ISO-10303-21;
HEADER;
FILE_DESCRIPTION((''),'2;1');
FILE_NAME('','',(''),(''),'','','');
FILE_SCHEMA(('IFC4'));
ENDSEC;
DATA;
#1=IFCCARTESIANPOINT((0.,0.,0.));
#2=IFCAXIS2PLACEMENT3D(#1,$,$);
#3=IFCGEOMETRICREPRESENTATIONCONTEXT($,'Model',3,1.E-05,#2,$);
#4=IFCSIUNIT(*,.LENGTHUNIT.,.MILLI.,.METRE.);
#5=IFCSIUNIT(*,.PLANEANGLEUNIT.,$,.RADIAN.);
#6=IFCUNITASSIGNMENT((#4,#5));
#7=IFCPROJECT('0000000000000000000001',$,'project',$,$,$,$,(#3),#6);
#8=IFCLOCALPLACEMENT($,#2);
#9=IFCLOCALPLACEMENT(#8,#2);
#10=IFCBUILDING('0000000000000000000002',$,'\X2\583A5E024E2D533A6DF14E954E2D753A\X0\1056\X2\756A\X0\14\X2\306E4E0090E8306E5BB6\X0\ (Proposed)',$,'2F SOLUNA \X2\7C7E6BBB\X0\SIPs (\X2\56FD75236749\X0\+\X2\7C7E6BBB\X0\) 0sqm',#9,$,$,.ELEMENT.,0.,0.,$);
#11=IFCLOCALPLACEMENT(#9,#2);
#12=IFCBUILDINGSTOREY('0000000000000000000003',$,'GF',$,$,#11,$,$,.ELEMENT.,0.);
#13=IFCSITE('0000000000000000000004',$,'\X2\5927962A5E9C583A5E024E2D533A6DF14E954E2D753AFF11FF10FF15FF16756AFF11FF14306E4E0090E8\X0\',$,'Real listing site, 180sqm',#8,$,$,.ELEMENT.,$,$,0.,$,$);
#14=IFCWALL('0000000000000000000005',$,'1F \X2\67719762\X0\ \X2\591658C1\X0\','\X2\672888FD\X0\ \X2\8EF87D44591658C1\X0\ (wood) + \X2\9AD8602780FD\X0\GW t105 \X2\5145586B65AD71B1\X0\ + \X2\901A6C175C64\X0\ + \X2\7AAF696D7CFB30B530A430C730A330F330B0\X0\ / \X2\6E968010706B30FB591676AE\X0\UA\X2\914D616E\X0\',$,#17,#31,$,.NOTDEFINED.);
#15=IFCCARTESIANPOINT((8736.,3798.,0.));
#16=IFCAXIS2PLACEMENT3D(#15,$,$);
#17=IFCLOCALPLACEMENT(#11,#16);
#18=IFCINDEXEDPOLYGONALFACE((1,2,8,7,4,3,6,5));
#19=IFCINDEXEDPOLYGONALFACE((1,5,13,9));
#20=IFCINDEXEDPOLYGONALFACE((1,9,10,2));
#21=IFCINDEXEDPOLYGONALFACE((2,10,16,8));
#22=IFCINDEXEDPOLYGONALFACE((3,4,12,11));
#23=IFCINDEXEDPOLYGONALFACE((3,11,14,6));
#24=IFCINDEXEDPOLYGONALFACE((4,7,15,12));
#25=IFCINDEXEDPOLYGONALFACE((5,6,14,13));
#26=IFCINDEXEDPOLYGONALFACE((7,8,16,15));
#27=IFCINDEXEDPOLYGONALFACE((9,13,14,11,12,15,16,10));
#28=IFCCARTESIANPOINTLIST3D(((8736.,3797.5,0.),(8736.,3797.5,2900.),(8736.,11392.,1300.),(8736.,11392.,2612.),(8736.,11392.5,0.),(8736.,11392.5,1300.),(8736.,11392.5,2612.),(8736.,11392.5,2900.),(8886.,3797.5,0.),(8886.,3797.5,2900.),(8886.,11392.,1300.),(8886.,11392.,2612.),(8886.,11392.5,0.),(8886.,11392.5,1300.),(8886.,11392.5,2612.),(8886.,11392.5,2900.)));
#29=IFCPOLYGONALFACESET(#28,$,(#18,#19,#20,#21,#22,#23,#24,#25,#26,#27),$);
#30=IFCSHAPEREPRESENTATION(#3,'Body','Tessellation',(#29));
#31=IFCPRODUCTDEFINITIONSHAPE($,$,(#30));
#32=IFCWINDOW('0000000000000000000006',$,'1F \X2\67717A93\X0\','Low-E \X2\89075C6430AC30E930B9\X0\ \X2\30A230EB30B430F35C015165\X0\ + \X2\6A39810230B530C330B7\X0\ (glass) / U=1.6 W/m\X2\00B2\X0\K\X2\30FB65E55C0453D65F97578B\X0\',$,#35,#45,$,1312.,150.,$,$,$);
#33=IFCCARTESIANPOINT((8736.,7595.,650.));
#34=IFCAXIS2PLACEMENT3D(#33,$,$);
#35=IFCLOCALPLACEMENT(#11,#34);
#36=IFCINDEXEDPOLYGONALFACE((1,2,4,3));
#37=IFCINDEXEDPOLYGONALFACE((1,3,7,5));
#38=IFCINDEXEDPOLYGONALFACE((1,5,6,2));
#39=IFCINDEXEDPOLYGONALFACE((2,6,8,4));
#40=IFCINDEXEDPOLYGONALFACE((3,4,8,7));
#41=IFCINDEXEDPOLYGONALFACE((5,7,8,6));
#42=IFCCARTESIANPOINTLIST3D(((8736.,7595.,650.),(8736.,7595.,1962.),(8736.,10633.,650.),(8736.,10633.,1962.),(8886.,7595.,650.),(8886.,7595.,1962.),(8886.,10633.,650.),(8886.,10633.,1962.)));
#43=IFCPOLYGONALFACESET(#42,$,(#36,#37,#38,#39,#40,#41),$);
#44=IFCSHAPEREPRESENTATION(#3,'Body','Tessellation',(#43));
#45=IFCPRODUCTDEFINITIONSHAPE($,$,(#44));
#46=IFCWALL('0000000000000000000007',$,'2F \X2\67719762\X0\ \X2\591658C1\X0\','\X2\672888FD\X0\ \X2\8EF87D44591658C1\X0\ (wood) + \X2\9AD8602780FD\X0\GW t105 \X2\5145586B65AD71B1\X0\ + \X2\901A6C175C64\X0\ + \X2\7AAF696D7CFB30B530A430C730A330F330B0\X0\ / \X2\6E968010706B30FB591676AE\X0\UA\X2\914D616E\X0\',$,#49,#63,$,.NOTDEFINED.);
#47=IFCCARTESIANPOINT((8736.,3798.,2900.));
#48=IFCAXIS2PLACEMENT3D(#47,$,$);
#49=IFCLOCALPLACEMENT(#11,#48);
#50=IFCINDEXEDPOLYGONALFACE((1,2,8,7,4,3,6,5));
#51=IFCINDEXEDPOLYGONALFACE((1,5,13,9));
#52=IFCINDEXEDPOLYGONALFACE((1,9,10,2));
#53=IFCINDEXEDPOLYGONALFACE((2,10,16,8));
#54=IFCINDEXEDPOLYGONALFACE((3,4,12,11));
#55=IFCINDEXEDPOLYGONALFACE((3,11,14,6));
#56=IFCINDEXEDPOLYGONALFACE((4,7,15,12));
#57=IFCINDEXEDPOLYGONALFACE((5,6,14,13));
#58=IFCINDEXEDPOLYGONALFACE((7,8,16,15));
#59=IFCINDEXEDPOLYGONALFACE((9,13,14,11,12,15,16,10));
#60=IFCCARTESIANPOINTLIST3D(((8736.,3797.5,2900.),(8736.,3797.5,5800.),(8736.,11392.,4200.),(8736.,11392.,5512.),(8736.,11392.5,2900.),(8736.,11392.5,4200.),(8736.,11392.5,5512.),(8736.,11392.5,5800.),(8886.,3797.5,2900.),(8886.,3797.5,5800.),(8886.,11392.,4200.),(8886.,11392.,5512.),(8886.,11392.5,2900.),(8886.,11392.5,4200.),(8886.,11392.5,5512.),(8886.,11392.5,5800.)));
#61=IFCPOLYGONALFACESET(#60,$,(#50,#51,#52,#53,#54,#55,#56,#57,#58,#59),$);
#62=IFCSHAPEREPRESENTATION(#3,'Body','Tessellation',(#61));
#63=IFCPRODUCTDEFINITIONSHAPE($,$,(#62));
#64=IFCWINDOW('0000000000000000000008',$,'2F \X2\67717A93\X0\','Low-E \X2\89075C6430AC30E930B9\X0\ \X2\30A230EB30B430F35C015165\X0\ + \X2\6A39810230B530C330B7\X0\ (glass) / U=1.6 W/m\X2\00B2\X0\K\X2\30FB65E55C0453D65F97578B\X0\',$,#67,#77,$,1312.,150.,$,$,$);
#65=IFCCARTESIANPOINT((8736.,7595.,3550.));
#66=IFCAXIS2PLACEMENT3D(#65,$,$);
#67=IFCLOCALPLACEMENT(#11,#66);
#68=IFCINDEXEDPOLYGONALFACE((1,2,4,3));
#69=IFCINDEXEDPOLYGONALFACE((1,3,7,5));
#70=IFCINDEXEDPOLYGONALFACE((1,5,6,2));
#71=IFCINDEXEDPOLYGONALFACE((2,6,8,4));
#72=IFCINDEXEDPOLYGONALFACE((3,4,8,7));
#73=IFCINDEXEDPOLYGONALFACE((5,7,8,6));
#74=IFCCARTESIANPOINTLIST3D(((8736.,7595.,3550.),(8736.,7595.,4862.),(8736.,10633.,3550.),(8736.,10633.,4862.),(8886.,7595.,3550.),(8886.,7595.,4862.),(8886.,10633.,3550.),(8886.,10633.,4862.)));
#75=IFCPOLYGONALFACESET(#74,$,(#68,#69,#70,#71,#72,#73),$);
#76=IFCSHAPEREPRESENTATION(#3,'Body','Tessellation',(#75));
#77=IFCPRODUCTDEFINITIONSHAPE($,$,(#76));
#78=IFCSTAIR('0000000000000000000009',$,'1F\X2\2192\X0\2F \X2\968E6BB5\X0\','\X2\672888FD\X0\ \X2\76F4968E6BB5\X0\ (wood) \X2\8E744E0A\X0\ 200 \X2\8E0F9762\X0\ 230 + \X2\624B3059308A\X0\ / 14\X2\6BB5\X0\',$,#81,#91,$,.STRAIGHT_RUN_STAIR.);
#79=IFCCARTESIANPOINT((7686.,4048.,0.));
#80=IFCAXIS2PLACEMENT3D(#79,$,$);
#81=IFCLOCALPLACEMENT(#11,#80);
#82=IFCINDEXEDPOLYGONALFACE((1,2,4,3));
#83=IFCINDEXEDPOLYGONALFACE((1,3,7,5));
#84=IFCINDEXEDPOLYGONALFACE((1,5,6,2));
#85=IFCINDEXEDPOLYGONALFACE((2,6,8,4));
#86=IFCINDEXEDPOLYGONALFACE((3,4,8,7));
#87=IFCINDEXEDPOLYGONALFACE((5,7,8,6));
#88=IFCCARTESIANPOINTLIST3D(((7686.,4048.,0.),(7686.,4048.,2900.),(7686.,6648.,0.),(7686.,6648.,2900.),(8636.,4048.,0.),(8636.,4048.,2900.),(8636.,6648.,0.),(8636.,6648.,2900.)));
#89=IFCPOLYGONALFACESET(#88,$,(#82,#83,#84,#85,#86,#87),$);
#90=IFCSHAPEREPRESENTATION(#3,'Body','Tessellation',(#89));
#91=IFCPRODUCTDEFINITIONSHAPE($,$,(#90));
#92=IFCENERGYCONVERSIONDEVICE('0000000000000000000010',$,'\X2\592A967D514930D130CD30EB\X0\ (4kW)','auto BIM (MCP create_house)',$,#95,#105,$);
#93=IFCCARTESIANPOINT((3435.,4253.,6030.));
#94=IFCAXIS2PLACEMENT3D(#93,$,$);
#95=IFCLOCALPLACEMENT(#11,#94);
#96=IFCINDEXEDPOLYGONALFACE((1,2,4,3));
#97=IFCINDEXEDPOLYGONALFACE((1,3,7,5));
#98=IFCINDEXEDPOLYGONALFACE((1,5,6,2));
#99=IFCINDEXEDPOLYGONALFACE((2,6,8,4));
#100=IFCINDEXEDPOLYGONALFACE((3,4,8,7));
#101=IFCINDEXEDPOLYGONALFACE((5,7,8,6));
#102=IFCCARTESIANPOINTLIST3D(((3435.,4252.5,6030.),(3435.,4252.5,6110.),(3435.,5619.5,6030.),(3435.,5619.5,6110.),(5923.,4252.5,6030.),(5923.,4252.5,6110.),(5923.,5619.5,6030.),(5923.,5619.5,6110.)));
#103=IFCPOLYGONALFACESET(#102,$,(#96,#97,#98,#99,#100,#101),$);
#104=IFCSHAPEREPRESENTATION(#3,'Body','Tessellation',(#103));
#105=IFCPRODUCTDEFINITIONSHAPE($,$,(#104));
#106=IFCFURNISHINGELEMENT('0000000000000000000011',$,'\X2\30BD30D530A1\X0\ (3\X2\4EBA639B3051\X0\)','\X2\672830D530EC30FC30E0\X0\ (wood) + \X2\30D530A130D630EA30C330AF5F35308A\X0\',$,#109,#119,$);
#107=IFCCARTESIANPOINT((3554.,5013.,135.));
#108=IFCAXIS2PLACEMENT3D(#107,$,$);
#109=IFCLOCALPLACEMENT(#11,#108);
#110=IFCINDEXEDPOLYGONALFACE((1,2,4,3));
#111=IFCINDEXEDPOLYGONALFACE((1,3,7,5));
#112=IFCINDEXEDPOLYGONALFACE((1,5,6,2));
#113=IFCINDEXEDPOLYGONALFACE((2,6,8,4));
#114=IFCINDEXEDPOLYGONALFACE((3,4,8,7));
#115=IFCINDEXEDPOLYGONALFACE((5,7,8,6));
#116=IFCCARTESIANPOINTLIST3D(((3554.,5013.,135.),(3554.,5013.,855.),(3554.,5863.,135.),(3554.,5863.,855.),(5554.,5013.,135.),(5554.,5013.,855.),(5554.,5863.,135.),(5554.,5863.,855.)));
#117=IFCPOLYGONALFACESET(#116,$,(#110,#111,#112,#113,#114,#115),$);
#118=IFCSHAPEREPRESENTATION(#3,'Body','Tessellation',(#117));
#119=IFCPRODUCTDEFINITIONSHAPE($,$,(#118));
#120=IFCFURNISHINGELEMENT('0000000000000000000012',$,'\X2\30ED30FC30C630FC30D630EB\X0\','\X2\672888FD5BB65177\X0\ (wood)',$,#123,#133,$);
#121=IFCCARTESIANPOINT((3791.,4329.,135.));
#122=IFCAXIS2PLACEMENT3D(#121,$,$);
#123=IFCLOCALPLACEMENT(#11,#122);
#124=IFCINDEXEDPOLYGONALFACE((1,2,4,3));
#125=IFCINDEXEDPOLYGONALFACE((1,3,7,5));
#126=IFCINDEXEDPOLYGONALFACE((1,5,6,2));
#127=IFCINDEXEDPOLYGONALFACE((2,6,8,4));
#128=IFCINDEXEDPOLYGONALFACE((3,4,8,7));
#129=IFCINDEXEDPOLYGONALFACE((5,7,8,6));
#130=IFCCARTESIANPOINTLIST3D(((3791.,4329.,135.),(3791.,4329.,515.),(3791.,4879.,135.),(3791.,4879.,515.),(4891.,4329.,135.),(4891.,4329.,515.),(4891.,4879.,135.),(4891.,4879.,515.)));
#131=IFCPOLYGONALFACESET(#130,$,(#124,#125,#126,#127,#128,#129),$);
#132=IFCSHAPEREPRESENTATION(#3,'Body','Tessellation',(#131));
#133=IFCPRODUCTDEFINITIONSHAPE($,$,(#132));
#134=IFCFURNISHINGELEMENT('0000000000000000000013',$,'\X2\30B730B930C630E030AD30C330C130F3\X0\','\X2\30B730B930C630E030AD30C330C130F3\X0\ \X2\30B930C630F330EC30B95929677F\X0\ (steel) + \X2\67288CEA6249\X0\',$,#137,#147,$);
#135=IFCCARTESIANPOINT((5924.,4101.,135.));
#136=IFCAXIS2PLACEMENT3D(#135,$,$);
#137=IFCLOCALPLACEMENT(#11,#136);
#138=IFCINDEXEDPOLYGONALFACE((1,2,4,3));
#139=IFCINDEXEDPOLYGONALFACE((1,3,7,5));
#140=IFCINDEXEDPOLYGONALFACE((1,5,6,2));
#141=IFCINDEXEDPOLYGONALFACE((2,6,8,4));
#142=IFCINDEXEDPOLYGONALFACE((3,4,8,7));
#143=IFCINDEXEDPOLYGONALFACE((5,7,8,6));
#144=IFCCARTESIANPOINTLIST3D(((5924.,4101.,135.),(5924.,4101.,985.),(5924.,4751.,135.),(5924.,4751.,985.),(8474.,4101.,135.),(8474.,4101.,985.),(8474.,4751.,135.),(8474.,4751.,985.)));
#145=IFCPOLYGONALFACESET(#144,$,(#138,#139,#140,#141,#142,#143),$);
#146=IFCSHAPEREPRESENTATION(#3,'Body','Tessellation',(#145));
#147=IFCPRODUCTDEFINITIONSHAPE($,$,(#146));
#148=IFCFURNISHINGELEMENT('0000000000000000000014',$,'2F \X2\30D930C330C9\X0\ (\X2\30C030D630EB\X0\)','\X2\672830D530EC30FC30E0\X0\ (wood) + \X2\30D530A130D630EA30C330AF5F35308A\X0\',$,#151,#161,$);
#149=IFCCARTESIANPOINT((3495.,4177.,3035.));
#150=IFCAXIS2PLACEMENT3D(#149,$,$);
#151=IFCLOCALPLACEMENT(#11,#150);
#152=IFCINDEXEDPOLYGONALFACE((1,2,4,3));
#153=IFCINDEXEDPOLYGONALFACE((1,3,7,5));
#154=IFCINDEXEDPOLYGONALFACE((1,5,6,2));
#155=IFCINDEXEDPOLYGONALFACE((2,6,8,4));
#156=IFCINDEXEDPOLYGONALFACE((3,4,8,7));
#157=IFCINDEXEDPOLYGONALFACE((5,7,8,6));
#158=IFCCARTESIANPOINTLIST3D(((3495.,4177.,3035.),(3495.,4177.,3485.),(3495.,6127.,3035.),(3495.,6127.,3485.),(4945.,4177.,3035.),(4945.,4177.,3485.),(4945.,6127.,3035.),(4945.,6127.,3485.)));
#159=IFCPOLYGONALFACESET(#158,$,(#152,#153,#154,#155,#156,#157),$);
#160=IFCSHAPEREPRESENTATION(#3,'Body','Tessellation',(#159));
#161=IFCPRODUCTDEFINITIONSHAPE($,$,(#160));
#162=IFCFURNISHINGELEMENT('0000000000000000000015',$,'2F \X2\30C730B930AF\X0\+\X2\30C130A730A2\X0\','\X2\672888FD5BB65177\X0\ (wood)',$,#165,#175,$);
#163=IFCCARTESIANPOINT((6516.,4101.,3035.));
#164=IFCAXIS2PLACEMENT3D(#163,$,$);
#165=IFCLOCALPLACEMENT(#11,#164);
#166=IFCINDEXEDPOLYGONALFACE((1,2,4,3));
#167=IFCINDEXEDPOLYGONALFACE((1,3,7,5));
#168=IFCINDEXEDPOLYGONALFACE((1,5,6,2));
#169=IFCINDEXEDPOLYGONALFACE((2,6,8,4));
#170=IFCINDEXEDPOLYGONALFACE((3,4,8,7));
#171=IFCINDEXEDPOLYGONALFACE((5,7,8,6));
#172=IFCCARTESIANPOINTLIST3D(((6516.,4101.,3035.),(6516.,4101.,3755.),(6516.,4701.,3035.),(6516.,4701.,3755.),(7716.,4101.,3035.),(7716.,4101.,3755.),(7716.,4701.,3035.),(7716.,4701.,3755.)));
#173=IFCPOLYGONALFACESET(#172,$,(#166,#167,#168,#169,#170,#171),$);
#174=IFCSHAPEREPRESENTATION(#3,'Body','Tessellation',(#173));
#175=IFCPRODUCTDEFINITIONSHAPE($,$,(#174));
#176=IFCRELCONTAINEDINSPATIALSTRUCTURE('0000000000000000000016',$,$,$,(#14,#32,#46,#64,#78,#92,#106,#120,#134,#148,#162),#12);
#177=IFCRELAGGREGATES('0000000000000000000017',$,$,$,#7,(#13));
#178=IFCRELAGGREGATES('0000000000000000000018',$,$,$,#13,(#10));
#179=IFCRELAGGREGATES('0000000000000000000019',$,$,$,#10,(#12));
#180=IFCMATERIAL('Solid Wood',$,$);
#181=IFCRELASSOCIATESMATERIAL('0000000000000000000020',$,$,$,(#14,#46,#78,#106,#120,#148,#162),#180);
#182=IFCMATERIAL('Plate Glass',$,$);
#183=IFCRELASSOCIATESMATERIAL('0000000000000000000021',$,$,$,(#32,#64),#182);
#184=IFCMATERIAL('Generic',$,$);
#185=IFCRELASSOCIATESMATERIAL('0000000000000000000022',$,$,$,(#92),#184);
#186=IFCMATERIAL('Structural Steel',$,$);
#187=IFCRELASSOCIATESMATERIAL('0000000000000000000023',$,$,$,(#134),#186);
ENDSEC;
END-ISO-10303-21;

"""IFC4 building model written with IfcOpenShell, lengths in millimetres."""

from ifc_helpers import new_model, si_unit, frame, frame_2d, origin, place, context, project, spatial, rectangle, extrude, material, element, fill, save


model = new_model("IFC4")

# Units and contexts
model_context = context("Model", 3, precision=1e-05, world=origin())
ifc_project = project(units=[si_unit("LENGTHUNIT", "METRE", prefix="MILLI"), si_unit("PLANEANGLEUNIT", "RADIAN")], contexts=[model_context])

# Site, building, storey
site_placement = place(None, origin())
site = spatial("IfcSite", under=ifc_project, at=site_placement, Name="大阪府堺市中区深井中町１０５６番１４の一部", ObjectType="Real listing site, 180sqm", CompositionType="ELEMENT", RefElevation=0.0)
building_placement = place(site_placement, origin())
building = spatial("IfcBuilding", under=site, at=building_placement, Name="堺市中区深井中町1056番14の一部の家 (Proposed)", ObjectType="2F SOLUNA 籾殻SIPs (国産杉+籾殻) 0sqm", CompositionType="ELEMENT", ElevationOfRefHeight=0.0, ElevationOfTerrain=0.0)
storey_placement = place(building_placement, origin())
storey = spatial("IfcBuildingStorey", under=building, at=storey_placement, Name="GF", CompositionType="ELEMENT", Elevation=0.0)

# Wall, opening, window
ifc_material_1 = material(Name="Solid Wood")
wall_1_placement = place(storey_placement, frame((8736.0, 3798.0, 0.0)))
wall_1 = element("IfcWall", 1, at=wall_1_placement, inside=storey, material=ifc_material_1, Name="1F 東面 外壁", Description="木製 軸組外壁 (wood) + 高性能GW t105 充填断熱 + 通気層 + 窯業系サイディング / 準耐火・外皮UA配慮", PredefinedType="NOTDEFINED", context=model_context, shape_type="SweptSolid", body=[
    extrude(rectangle(XDim=150.0, YDim=7595.0, at=frame_2d((75.0, 3797.0))), frame((8736.0, 3798.0, 0.0)), (0.0, 0.0, 1.0), 2900.0),
])
opening_1_placement = place(storey_placement, frame((8736.0, 7595.0, 650.0)))
opening_1 = element("IfcOpeningElement", 2, at=opening_1_placement, cuts=wall_1, PredefinedType="NOTDEFINED", context=model_context, shape_type="SweptSolid", body=[
    extrude(rectangle(XDim=150.0, YDim=3038.0, at=frame_2d((75.0, 1519.0))), frame((8736.0, 7595.0, 650.0)), (0.0, 0.0, 1.0), 1312.0),
])
ifc_material_2 = material(Name="Plate Glass")
window_1_placement = place(storey_placement, frame((8736.0, 7595.0, 650.0)))
window_1 = element("IfcWindow", 3, at=window_1_placement, inside=storey, material=ifc_material_2, Name="1F 東窓", Description="Low-E 複層ガラス アルゴン封入 + 樹脂サッシ (glass) / U=1.6 W/m²K・日射取得型", OverallHeight=1312.0, OverallWidth=150.0, context=model_context, shape_type="SweptSolid", body=[
    extrude(rectangle(XDim=150.0, YDim=3038.0, at=frame_2d((75.0, 1519.0))), frame((8736.0, 7595.0, 650.0)), (0.0, 0.0, 1.0), 1312.0),
])
fill(opening_1, window_1)

# Wall, opening, window
wall_2_placement = place(storey_placement, frame((8736.0, 3798.0, 2900.0)))
wall_2 = element("IfcWall", 4, at=wall_2_placement, inside=storey, material=ifc_material_1, Name="2F 東面 外壁", Description="木製 軸組外壁 (wood) + 高性能GW t105 充填断熱 + 通気層 + 窯業系サイディング / 準耐火・外皮UA配慮", PredefinedType="NOTDEFINED", context=model_context, shape_type="SweptSolid", body=[
    extrude(rectangle(XDim=150.0, YDim=7595.0, at=frame_2d((75.0, 3797.0))), frame((8736.0, 3798.0, 2900.0)), (0.0, 0.0, 1.0), 2900.0),
])
opening_2_placement = place(storey_placement, frame((8736.0, 7595.0, 3550.0)))
opening_2 = element("IfcOpeningElement", 5, at=opening_2_placement, cuts=wall_2, PredefinedType="NOTDEFINED", context=model_context, shape_type="SweptSolid", body=[
    extrude(rectangle(XDim=150.0, YDim=3038.0, at=frame_2d((75.0, 1519.0))), frame((8736.0, 7595.0, 3550.0)), (0.0, 0.0, 1.0), 1312.0),
])
window_2_placement = place(storey_placement, frame((8736.0, 7595.0, 3550.0)))
window_2 = element("IfcWindow", 6, at=window_2_placement, inside=storey, material=ifc_material_2, Name="2F 東窓", Description="Low-E 複層ガラス アルゴン封入 + 樹脂サッシ (glass) / U=1.6 W/m²K・日射取得型", OverallHeight=1312.0, OverallWidth=150.0, context=model_context, shape_type="SweptSolid", body=[
    extrude(rectangle(XDim=150.0, YDim=3038.0, at=frame_2d((75.0, 1519.0))), frame((8736.0, 7595.0, 3550.0)), (0.0, 0.0, 1.0), 1312.0),
])
fill(opening_2, window_2)

# Stair
stair_placement = place(storey_placement, frame((7686.0, 4048.0, 0.0)))
element("IfcStair", 7, at=stair_placement, inside=storey, material=ifc_material_1, Name="1F→2F 階段", Description="木製 直階段 (wood) 蹴上 200 踏面 230 + 手すり / 14段", PredefinedType="STRAIGHT_RUN_STAIR", context=model_context, shape_type="SweptSolid", body=[
    extrude(rectangle(XDim=950.0, YDim=2600.0, at=frame_2d((475.0, 1300.0))), frame((7686.0, 4048.0, 0.0)), (0.0, 0.0, 1.0), 2900.0),
])

# Energy conversion device
ifc_material_3 = material(Name="Generic")
energy_conversion_device_placement = place(storey_placement, frame((3435.0, 4253.0, 6030.0)))
element("IfcEnergyConversionDevice", 8, at=energy_conversion_device_placement, inside=storey, material=ifc_material_3, Name="太陽光パネル (4kW)", Description="auto BIM (MCP create_house)", context=model_context, shape_type="SweptSolid", body=[
    extrude(rectangle(XDim=2488.0, YDim=1367.0, at=frame_2d((1244.0, 683.0))), frame((3435.0, 4253.0, 6030.0)), (0.0, 0.0, 1.0), 80.0),
])

# Furnishing elements
furnishing_1_placement = place(storey_placement, frame((3554.0, 5013.0, 135.0)))
element("IfcFurnishingElement", 9, at=furnishing_1_placement, inside=storey, material=ifc_material_1, Name="ソファ (3人掛け)", Description="木フレーム (wood) + ファブリック張り", context=model_context, shape_type="SweptSolid", body=[
    extrude(rectangle(XDim=2000.0, YDim=850.0, at=frame_2d((1000.0, 425.0))), frame((3554.0, 5013.0, 135.0)), (0.0, 0.0, 1.0), 720.0),
])
furnishing_2_placement = place(storey_placement, frame((3791.0, 4329.0, 135.0)))
element("IfcFurnishingElement", 10, at=furnishing_2_placement, inside=storey, material=ifc_material_1, Name="ローテーブル", Description="木製家具 (wood)", context=model_context, shape_type="SweptSolid", body=[
    extrude(rectangle(XDim=1100.0, YDim=550.0, at=frame_2d((550.0, 275.0))), frame((3791.0, 4329.0, 135.0)), (0.0, 0.0, 1.0), 380.0),
])
ifc_material_4 = material(Name="Structural Steel")
furnishing_3_placement = place(storey_placement, frame((5924.0, 4101.0, 135.0)))
element("IfcFurnishingElement", 11, at=furnishing_3_placement, inside=storey, material=ifc_material_4, Name="システムキッチン", Description="システムキッチン ステンレス天板 (steel) + 木質扉", context=model_context, shape_type="SweptSolid", body=[
    extrude(rectangle(XDim=2550.0, YDim=650.0, at=frame_2d((1275.0, 325.0))), frame((5924.0, 4101.0, 135.0)), (0.0, 0.0, 1.0), 850.0),
])
furnishing_4_placement = place(storey_placement, frame((3495.0, 4177.0, 3035.0)))
element("IfcFurnishingElement", 12, at=furnishing_4_placement, inside=storey, material=ifc_material_1, Name="2F ベッド (ダブル)", Description="木フレーム (wood) + ファブリック張り", context=model_context, shape_type="SweptSolid", body=[
    extrude(rectangle(XDim=1450.0, YDim=1950.0, at=frame_2d((725.0, 975.0))), frame((3495.0, 4177.0, 3035.0)), (0.0, 0.0, 1.0), 450.0),
])
furnishing_5_placement = place(storey_placement, frame((6516.0, 4101.0, 3035.0)))
element("IfcFurnishingElement", 13, at=furnishing_5_placement, inside=storey, material=ifc_material_1, Name="2F デスク+チェア", Description="木製家具 (wood)", context=model_context, shape_type="SweptSolid", body=[
    extrude(rectangle(XDim=1200.0, YDim=600.0, at=frame_2d((600.0, 300.0))), frame((6516.0, 4101.0, 3035.0)), (0.0, 0.0, 1.0), 720.0),
])

save(model, "model.ifc")
